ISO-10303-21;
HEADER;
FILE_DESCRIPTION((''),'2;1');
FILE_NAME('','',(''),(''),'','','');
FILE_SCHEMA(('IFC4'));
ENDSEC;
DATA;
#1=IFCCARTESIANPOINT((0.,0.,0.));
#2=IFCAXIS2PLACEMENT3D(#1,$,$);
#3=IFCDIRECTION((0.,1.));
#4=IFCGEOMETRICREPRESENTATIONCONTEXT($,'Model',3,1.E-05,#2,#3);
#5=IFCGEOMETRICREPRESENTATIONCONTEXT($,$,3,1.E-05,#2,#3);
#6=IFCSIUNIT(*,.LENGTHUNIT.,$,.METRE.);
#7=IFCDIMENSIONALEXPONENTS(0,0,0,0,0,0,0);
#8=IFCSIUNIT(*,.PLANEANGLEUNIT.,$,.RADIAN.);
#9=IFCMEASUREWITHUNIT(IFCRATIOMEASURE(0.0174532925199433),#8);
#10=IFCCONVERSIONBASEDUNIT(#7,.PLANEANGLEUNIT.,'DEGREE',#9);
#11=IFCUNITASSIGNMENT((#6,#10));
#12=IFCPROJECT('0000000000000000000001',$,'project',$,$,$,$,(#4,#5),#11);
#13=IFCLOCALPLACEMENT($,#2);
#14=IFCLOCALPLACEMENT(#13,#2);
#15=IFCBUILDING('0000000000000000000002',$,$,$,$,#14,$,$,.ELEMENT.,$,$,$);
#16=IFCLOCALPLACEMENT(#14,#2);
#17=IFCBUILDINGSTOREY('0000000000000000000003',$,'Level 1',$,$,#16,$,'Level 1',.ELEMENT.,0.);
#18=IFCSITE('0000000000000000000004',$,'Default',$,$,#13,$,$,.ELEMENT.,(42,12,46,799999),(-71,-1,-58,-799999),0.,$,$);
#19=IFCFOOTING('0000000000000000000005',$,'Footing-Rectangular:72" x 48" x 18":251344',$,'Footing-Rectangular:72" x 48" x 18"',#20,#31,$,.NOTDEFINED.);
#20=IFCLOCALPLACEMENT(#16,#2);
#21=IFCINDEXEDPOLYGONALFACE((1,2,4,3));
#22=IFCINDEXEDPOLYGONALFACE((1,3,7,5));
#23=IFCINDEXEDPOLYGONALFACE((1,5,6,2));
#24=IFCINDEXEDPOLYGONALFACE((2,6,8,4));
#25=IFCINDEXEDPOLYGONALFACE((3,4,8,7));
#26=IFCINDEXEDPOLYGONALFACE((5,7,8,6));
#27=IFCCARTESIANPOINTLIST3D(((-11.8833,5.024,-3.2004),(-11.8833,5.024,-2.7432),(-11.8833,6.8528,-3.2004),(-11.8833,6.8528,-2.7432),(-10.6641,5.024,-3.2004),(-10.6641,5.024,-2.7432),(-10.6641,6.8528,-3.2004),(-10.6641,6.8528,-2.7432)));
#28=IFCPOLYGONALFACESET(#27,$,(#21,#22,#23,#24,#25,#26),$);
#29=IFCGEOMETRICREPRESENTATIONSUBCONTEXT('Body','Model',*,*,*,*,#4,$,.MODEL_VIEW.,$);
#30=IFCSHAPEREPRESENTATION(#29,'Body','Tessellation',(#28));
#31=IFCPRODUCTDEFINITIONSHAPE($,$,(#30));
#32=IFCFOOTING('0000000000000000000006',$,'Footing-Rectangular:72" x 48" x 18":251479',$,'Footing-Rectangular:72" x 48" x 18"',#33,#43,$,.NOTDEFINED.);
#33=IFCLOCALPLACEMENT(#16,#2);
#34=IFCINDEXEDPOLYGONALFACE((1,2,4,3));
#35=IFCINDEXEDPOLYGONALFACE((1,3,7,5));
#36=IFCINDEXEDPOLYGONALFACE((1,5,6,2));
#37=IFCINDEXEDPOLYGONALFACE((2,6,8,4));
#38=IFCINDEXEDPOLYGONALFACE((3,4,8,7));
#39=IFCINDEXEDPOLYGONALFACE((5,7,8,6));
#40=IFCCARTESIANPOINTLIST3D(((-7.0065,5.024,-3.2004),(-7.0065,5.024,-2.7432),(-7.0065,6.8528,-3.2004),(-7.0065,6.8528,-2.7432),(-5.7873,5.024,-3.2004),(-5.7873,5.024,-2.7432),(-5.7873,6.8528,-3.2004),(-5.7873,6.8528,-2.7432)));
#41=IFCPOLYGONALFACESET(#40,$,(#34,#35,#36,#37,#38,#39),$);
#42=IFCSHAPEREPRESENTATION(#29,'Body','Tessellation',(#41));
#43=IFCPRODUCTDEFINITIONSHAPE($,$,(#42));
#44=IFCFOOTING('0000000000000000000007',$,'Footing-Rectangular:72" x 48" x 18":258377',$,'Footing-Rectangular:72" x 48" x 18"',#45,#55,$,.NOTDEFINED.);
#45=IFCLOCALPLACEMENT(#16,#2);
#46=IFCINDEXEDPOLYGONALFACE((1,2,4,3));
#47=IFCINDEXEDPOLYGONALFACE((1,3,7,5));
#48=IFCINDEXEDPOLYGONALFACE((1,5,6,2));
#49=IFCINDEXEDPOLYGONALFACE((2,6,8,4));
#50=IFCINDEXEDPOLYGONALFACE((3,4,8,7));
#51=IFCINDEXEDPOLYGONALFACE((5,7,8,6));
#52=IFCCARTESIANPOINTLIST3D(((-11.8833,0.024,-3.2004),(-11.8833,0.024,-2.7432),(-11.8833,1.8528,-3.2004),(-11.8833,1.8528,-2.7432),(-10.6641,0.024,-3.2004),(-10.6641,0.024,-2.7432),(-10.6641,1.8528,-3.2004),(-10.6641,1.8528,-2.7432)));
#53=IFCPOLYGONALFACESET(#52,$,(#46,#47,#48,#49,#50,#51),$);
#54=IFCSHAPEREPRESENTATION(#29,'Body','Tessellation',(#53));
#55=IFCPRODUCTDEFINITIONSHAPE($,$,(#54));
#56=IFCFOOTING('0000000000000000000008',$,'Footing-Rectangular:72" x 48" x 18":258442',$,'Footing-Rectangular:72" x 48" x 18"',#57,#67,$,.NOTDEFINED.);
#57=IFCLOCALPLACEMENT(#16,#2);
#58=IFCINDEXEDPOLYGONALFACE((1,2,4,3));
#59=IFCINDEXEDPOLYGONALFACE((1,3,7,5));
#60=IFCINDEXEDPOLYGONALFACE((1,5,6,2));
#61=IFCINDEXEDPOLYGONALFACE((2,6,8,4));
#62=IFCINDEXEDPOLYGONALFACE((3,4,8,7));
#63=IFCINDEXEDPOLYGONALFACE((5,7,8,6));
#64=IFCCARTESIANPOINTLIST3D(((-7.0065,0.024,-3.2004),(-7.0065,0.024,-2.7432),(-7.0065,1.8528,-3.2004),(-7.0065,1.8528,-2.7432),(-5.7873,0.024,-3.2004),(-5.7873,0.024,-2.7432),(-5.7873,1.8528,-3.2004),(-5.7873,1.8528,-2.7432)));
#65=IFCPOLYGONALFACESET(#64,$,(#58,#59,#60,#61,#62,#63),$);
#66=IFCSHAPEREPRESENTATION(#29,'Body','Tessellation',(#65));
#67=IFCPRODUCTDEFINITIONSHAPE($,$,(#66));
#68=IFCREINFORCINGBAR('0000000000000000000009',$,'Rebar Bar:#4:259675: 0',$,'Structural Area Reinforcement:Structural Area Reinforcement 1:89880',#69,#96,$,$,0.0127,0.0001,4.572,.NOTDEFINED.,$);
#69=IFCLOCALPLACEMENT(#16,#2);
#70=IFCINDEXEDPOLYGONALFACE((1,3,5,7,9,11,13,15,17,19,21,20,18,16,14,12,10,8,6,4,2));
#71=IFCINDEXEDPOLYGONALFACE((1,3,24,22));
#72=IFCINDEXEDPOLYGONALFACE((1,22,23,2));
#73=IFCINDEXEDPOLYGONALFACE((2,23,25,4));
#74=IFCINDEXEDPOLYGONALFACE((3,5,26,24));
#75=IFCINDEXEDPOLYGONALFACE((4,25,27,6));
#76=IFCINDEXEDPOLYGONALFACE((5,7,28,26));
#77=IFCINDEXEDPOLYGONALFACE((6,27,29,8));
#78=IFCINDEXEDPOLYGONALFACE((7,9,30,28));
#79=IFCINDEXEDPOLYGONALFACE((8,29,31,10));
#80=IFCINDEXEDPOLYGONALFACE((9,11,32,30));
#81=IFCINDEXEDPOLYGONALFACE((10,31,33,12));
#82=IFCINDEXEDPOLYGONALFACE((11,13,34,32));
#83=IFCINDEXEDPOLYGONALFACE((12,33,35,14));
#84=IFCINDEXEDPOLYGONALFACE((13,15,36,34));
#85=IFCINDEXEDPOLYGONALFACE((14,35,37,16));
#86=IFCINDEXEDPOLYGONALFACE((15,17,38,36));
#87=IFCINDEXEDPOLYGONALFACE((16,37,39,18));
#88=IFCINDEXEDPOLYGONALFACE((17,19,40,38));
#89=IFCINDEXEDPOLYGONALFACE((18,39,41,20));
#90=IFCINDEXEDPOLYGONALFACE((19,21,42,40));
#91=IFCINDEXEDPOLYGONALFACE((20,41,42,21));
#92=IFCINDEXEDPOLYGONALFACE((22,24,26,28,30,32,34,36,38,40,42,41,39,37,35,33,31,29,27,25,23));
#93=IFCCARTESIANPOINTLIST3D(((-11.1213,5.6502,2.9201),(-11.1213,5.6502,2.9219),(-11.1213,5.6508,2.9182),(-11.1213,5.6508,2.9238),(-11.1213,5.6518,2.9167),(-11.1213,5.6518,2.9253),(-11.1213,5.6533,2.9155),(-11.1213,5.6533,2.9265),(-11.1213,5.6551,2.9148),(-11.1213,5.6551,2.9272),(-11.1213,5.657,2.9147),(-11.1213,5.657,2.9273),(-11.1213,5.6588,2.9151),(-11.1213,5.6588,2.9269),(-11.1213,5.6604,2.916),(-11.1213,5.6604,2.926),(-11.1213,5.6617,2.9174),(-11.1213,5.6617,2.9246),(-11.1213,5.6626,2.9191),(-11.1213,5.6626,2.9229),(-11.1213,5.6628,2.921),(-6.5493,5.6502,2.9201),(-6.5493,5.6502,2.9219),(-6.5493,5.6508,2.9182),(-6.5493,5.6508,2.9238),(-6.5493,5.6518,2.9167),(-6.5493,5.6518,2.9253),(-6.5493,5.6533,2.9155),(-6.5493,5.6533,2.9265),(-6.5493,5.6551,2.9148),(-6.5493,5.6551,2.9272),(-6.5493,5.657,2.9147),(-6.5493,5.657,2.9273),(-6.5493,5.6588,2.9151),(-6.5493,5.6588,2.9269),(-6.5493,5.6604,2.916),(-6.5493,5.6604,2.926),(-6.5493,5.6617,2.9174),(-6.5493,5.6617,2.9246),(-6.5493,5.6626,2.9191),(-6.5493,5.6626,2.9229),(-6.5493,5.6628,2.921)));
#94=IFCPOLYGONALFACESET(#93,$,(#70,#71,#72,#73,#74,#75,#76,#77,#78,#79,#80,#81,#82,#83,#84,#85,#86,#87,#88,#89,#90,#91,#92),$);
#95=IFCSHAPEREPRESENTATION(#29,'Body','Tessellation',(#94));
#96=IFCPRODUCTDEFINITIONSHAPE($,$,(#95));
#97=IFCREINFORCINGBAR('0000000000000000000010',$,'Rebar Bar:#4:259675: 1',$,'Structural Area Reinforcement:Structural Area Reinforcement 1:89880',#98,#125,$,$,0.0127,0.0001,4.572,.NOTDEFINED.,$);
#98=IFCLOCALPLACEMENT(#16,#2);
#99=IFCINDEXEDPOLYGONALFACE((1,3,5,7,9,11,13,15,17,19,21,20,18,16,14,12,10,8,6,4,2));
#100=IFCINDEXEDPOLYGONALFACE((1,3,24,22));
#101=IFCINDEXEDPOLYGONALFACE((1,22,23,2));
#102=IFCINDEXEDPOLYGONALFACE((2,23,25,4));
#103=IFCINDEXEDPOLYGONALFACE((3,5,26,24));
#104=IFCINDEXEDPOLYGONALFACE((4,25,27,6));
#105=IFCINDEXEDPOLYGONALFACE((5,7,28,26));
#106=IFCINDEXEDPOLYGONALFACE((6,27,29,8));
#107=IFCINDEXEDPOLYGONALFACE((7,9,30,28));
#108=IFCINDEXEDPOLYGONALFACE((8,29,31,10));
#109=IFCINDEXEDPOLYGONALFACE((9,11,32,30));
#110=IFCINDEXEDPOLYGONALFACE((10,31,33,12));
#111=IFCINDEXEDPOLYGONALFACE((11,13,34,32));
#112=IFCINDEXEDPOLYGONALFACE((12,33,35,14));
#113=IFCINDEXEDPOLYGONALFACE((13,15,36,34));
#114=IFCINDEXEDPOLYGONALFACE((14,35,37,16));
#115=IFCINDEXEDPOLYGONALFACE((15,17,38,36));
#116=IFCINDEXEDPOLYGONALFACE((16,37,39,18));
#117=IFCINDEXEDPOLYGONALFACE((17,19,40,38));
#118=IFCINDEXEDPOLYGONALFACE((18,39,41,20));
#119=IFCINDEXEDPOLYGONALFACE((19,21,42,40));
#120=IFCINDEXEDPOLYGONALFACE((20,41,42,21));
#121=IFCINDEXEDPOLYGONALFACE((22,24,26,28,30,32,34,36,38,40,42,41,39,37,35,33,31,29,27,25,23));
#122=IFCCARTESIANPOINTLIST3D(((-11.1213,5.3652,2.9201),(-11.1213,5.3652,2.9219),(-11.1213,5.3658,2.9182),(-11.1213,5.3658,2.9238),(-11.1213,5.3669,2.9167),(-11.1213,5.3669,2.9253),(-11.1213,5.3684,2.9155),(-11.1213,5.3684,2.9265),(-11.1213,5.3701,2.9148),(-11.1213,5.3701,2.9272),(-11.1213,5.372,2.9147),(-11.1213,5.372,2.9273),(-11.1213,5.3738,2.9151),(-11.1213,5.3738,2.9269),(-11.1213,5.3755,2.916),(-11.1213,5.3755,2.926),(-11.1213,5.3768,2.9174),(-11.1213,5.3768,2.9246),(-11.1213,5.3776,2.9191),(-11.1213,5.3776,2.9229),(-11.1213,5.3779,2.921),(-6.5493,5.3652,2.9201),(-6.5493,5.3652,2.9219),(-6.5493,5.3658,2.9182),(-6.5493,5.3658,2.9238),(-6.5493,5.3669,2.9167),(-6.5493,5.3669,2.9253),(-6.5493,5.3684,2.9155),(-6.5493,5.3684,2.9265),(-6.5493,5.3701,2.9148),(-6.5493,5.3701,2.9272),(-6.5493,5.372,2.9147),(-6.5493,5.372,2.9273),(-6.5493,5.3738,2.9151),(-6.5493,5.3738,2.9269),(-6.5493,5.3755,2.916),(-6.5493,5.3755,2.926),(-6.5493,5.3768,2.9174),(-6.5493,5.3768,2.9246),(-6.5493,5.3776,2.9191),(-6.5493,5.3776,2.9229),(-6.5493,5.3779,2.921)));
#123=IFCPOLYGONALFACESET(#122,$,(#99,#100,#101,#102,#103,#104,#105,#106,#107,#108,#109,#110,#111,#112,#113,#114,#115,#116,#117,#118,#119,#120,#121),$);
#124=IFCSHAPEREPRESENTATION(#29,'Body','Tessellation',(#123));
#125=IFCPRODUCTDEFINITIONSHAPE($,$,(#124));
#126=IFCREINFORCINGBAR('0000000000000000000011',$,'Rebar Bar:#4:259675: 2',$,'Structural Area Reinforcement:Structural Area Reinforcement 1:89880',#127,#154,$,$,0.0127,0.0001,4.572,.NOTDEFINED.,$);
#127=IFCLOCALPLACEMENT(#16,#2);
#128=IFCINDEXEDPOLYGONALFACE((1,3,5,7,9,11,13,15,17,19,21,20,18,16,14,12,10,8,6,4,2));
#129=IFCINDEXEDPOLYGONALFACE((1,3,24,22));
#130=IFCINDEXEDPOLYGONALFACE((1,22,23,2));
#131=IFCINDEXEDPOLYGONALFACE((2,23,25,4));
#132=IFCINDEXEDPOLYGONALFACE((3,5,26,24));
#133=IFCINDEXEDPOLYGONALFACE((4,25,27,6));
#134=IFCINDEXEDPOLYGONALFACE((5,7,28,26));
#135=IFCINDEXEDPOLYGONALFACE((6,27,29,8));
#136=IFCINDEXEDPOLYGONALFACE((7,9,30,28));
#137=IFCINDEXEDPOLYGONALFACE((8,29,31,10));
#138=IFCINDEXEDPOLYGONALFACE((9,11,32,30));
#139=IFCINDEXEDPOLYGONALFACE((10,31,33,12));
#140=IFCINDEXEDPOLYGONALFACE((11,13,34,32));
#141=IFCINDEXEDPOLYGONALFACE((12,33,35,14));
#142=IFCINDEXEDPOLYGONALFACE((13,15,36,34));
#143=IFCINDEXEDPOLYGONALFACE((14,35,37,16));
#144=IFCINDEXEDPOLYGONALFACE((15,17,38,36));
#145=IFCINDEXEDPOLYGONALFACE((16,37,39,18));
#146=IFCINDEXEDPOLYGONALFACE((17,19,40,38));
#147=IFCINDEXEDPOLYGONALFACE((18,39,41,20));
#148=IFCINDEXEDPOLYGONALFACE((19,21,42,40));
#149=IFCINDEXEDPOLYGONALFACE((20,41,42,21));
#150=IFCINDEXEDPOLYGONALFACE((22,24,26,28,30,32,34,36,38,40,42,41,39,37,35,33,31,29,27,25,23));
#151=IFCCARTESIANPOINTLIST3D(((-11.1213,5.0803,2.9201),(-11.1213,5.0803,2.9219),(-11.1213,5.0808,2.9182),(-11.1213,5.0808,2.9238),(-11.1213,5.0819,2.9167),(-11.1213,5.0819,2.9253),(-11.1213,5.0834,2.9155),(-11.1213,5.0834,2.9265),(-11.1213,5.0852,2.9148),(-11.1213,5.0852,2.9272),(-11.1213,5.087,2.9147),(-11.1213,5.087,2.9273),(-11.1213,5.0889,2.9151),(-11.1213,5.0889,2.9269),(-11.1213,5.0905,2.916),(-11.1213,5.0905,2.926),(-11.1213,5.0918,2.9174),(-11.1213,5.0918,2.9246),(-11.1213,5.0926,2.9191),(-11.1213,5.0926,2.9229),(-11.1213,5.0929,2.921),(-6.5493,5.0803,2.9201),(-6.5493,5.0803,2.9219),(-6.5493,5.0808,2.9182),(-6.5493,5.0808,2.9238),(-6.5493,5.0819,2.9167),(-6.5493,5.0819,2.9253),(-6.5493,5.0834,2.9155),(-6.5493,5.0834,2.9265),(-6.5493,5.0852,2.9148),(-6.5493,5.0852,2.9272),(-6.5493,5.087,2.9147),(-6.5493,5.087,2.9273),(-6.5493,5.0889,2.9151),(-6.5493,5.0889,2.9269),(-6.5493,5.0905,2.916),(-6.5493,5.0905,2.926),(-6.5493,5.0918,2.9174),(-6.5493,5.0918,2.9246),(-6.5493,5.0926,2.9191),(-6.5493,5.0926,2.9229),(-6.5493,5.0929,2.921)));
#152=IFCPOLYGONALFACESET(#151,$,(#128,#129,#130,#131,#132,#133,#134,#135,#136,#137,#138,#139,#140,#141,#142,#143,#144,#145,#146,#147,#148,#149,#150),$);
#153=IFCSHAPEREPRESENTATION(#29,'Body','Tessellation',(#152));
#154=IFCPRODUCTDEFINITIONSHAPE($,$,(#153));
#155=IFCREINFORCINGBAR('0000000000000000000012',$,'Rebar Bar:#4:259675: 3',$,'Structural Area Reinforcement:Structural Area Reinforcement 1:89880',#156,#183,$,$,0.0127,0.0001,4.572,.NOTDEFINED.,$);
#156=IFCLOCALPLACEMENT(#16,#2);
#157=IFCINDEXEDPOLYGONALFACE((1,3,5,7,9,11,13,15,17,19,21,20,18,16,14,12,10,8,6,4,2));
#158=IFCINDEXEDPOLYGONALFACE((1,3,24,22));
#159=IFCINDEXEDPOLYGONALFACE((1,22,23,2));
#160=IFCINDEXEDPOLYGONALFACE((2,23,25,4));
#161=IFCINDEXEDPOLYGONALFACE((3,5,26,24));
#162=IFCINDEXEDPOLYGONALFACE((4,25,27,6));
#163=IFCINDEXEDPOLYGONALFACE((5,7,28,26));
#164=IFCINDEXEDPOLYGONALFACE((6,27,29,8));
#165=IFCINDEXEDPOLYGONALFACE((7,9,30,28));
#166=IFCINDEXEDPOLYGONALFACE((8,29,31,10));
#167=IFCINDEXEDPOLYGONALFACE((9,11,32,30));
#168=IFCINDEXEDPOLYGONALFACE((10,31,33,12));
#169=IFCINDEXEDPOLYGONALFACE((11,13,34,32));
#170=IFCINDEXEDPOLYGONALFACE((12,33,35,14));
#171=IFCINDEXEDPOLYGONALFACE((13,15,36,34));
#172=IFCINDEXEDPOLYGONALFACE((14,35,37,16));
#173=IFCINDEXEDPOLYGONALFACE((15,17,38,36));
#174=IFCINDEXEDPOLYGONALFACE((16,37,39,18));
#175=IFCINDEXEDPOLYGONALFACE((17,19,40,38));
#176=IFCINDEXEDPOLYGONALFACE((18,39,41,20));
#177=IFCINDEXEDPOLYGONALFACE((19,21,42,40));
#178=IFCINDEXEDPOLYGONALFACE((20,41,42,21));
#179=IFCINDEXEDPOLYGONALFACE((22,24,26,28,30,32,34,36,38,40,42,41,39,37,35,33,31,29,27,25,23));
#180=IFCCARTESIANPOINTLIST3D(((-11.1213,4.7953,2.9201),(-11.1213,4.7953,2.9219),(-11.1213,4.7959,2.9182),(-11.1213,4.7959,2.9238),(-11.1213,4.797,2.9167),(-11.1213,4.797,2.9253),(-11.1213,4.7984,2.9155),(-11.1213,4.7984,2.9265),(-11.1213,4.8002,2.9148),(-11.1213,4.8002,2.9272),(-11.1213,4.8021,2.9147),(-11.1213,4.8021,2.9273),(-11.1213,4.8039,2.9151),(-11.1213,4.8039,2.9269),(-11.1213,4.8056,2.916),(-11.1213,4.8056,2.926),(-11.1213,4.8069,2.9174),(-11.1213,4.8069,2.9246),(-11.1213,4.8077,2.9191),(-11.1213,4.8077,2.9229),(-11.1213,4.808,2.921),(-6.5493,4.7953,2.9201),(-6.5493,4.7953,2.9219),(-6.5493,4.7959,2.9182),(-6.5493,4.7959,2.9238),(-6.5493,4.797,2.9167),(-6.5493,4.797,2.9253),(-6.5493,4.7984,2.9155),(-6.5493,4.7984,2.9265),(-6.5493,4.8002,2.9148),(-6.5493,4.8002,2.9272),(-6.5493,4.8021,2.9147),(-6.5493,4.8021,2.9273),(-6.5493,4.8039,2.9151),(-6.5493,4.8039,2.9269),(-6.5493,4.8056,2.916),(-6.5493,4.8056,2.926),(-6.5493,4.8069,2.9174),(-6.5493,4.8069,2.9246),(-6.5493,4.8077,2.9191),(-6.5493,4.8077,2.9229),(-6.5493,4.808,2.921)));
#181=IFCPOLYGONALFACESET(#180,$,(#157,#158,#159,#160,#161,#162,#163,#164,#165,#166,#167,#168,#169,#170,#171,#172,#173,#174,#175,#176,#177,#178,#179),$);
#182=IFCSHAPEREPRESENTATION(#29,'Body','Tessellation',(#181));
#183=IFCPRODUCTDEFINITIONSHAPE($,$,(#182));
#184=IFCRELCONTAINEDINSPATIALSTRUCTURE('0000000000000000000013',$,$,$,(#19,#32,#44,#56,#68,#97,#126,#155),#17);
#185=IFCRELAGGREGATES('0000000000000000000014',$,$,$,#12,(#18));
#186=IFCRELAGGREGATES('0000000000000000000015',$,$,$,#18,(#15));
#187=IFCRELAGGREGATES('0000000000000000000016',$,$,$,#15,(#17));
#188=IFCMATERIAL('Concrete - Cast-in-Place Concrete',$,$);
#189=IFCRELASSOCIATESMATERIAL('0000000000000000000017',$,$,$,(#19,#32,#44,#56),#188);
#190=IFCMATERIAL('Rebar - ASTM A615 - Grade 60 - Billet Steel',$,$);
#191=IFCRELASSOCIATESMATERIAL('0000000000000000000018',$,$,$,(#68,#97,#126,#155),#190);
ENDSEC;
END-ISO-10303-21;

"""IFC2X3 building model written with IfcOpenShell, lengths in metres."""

from ifc_helpers import new_model, entity, si_unit, converted_unit, direction, frame, origin, origin_2d_with_axis, place, context, subcontext, project, spatial, rectangle, extrude, material, element, save


model = new_model("IFC2X3")

# Units and contexts
model_context = context("Model", 3, precision=1e-05, world=origin(), true_north=direction((0.0, 1.0)))
context_of_model = context(None, 3, precision=1e-05, world=origin(), true_north=direction((0.0, 1.0)))
body_context = subcontext(model_context, "Body", "Model", "MODEL_VIEW")
ifc_project = project(units=[si_unit("LENGTHUNIT", "METRE"), converted_unit("PLANEANGLEUNIT", "DEGREE", entity("IfcRatioMeasure", 0.0174532925199433), si_unit("PLANEANGLEUNIT", "RADIAN"), dimensions=[0, 0, 0, 0, 0, 0, 0])], contexts=[model_context, context_of_model])

# Site, building, storey
site_placement = place(None, origin())
site = spatial("IfcSite", under=ifc_project, at=site_placement, Name="Default", CompositionType="ELEMENT", RefLatitude=(42, 12, 46, 799999), RefLongitude=(-71, -1, -58, -799999), RefElevation=0.0)
building_placement = place(site_placement, origin())
building = spatial("IfcBuilding", under=site, at=building_placement, CompositionType="ELEMENT")
storey_placement = place(building_placement, origin())
storey = spatial("IfcBuildingStorey", under=building, at=storey_placement, Name="Level 1", LongName="Level 1", CompositionType="ELEMENT", Elevation=0.0)

# Footings
ifc_material_1 = material(Name="Concrete - Cast-in-Place Concrete")
footing_1_placement = place(storey_placement, origin())
element("IfcFooting", 1, at=footing_1_placement, inside=storey, material=ifc_material_1, Name="Footing-Rectangular:72\" x 48\" x 18\":251344", ObjectType="Footing-Rectangular:72\" x 48\" x 18\"", PredefinedType="NOTDEFINED", context=body_context, shape_type="SweptSolid", body=[
    extrude(rectangle(XDim=1.2192, YDim=1.8288, at=origin_2d_with_axis()), frame((-11.2737, 5.9384, -3.2004), z_axis=(0.0, 0.0, 1.0), x_axis=(-1.0, 0.0, 0.0)), (0.0, 0.0, 1.0), 0.4572),
])
footing_2_placement = place(storey_placement, origin())
element("IfcFooting", 2, at=footing_2_placement, inside=storey, material=ifc_material_1, Name="Footing-Rectangular:72\" x 48\" x 18\":251479", ObjectType="Footing-Rectangular:72\" x 48\" x 18\"", PredefinedType="NOTDEFINED", context=body_context, shape_type="SweptSolid", body=[
    extrude(rectangle(XDim=1.2192, YDim=1.8288, at=origin_2d_with_axis()), frame((-6.3969, 5.9384, -3.2004), z_axis=(0.0, 0.0, 1.0), x_axis=(-1.0, 0.0, 0.0)), (0.0, 0.0, 1.0), 0.4572),
])
footing_3_placement = place(storey_placement, origin())
element("IfcFooting", 3, at=footing_3_placement, inside=storey, material=ifc_material_1, Name="Footing-Rectangular:72\" x 48\" x 18\":258377", ObjectType="Footing-Rectangular:72\" x 48\" x 18\"", PredefinedType="NOTDEFINED", context=body_context, shape_type="SweptSolid", body=[
    extrude(rectangle(XDim=1.2192, YDim=1.8288, at=origin_2d_with_axis()), frame((-11.2737, 0.9384, -3.2004), z_axis=(0.0, 0.0, 1.0), x_axis=(-1.0, 0.0, 0.0)), (0.0, 0.0, 1.0), 0.4572),
])
footing_4_placement = place(storey_placement, origin())
element("IfcFooting", 4, at=footing_4_placement, inside=storey, material=ifc_material_1, Name="Footing-Rectangular:72\" x 48\" x 18\":258442", ObjectType="Footing-Rectangular:72\" x 48\" x 18\"", PredefinedType="NOTDEFINED", context=body_context, shape_type="SweptSolid", body=[
    extrude(rectangle(XDim=1.2192, YDim=1.8288, at=origin_2d_with_axis()), frame((-6.3969, 0.9384, -3.2004), z_axis=(0.0, 0.0, 1.0), x_axis=(-1.0, 0.0, 0.0)), (0.0, 0.0, 1.0), 0.4572),
])

# Reinforcing bars
ifc_material_2 = material(Name="Rebar - ASTM A615 - Grade 60 - Billet Steel")
reinforcing_bar_1_placement = place(storey_placement, origin())
element("IfcReinforcingBar", 5, at=reinforcing_bar_1_placement, inside=storey, material=ifc_material_2, Name="Rebar Bar:#4:259675: 0", ObjectType="Structural Area Reinforcement:Structural Area Reinforcement 1:89880", BarLength=4.572, BarRole="NOTDEFINED", CrossSectionArea=0.0001, NominalDiameter=0.0127, context=body_context, shape_type="AdvancedSweptSolid", body=[
    entity("IfcSweptDiskSolid", entity("IfcCompositeCurve", [entity("IfcCompositeCurveSegment", "CONTINUOUS", True, entity("IfcPolyline", [entity("IfcCartesianPoint", [-11.1213, 5.6565, 2.921]), entity("IfcCartesianPoint", [-6.5493, 5.6565, 2.921])]))], False), 0.0063, None, 0.0, 1.0),
])
reinforcing_bar_2_placement = place(storey_placement, origin())
element("IfcReinforcingBar", 6, at=reinforcing_bar_2_placement, inside=storey, material=ifc_material_2, Name="Rebar Bar:#4:259675: 1", ObjectType="Structural Area Reinforcement:Structural Area Reinforcement 1:89880", BarLength=4.572, BarRole="NOTDEFINED", CrossSectionArea=0.0001, NominalDiameter=0.0127, context=body_context, shape_type="AdvancedSweptSolid", body=[
    entity("IfcSweptDiskSolid", entity("IfcCompositeCurve", [entity("IfcCompositeCurveSegment", "CONTINUOUS", True, entity("IfcPolyline", [entity("IfcCartesianPoint", [-11.1213, 5.3715, 2.921]), entity("IfcCartesianPoint", [-6.5493, 5.3715, 2.921])]))], False), 0.0063, None, 0.0, 1.0),
])
reinforcing_bar_3_placement = place(storey_placement, origin())
element("IfcReinforcingBar", 7, at=reinforcing_bar_3_placement, inside=storey, material=ifc_material_2, Name="Rebar Bar:#4:259675: 2", ObjectType="Structural Area Reinforcement:Structural Area Reinforcement 1:89880", BarLength=4.572, BarRole="NOTDEFINED", CrossSectionArea=0.0001, NominalDiameter=0.0127, context=body_context, shape_type="AdvancedSweptSolid", body=[
    entity("IfcSweptDiskSolid", entity("IfcCompositeCurve", [entity("IfcCompositeCurveSegment", "CONTINUOUS", True, entity("IfcPolyline", [entity("IfcCartesianPoint", [-11.1213, 5.0866, 2.921]), entity("IfcCartesianPoint", [-6.5493, 5.0866, 2.921])]))], False), 0.0063, None, 0.0, 1.0),
])
reinforcing_bar_4_placement = place(storey_placement, origin())
element("IfcReinforcingBar", 8, at=reinforcing_bar_4_placement, inside=storey, material=ifc_material_2, Name="Rebar Bar:#4:259675: 3", ObjectType="Structural Area Reinforcement:Structural Area Reinforcement 1:89880", BarLength=4.572, BarRole="NOTDEFINED", CrossSectionArea=0.0001, NominalDiameter=0.0127, context=body_context, shape_type="AdvancedSweptSolid", body=[
    entity("IfcSweptDiskSolid", entity("IfcCompositeCurve", [entity("IfcCompositeCurveSegment", "CONTINUOUS", True, entity("IfcPolyline", [entity("IfcCartesianPoint", [-11.1213, 4.8016, 2.921]), entity("IfcCartesianPoint", [-6.5493, 4.8016, 2.921])]))], False), 0.0063, None, 0.0, 1.0),
])

save(model, "model.ifc")
